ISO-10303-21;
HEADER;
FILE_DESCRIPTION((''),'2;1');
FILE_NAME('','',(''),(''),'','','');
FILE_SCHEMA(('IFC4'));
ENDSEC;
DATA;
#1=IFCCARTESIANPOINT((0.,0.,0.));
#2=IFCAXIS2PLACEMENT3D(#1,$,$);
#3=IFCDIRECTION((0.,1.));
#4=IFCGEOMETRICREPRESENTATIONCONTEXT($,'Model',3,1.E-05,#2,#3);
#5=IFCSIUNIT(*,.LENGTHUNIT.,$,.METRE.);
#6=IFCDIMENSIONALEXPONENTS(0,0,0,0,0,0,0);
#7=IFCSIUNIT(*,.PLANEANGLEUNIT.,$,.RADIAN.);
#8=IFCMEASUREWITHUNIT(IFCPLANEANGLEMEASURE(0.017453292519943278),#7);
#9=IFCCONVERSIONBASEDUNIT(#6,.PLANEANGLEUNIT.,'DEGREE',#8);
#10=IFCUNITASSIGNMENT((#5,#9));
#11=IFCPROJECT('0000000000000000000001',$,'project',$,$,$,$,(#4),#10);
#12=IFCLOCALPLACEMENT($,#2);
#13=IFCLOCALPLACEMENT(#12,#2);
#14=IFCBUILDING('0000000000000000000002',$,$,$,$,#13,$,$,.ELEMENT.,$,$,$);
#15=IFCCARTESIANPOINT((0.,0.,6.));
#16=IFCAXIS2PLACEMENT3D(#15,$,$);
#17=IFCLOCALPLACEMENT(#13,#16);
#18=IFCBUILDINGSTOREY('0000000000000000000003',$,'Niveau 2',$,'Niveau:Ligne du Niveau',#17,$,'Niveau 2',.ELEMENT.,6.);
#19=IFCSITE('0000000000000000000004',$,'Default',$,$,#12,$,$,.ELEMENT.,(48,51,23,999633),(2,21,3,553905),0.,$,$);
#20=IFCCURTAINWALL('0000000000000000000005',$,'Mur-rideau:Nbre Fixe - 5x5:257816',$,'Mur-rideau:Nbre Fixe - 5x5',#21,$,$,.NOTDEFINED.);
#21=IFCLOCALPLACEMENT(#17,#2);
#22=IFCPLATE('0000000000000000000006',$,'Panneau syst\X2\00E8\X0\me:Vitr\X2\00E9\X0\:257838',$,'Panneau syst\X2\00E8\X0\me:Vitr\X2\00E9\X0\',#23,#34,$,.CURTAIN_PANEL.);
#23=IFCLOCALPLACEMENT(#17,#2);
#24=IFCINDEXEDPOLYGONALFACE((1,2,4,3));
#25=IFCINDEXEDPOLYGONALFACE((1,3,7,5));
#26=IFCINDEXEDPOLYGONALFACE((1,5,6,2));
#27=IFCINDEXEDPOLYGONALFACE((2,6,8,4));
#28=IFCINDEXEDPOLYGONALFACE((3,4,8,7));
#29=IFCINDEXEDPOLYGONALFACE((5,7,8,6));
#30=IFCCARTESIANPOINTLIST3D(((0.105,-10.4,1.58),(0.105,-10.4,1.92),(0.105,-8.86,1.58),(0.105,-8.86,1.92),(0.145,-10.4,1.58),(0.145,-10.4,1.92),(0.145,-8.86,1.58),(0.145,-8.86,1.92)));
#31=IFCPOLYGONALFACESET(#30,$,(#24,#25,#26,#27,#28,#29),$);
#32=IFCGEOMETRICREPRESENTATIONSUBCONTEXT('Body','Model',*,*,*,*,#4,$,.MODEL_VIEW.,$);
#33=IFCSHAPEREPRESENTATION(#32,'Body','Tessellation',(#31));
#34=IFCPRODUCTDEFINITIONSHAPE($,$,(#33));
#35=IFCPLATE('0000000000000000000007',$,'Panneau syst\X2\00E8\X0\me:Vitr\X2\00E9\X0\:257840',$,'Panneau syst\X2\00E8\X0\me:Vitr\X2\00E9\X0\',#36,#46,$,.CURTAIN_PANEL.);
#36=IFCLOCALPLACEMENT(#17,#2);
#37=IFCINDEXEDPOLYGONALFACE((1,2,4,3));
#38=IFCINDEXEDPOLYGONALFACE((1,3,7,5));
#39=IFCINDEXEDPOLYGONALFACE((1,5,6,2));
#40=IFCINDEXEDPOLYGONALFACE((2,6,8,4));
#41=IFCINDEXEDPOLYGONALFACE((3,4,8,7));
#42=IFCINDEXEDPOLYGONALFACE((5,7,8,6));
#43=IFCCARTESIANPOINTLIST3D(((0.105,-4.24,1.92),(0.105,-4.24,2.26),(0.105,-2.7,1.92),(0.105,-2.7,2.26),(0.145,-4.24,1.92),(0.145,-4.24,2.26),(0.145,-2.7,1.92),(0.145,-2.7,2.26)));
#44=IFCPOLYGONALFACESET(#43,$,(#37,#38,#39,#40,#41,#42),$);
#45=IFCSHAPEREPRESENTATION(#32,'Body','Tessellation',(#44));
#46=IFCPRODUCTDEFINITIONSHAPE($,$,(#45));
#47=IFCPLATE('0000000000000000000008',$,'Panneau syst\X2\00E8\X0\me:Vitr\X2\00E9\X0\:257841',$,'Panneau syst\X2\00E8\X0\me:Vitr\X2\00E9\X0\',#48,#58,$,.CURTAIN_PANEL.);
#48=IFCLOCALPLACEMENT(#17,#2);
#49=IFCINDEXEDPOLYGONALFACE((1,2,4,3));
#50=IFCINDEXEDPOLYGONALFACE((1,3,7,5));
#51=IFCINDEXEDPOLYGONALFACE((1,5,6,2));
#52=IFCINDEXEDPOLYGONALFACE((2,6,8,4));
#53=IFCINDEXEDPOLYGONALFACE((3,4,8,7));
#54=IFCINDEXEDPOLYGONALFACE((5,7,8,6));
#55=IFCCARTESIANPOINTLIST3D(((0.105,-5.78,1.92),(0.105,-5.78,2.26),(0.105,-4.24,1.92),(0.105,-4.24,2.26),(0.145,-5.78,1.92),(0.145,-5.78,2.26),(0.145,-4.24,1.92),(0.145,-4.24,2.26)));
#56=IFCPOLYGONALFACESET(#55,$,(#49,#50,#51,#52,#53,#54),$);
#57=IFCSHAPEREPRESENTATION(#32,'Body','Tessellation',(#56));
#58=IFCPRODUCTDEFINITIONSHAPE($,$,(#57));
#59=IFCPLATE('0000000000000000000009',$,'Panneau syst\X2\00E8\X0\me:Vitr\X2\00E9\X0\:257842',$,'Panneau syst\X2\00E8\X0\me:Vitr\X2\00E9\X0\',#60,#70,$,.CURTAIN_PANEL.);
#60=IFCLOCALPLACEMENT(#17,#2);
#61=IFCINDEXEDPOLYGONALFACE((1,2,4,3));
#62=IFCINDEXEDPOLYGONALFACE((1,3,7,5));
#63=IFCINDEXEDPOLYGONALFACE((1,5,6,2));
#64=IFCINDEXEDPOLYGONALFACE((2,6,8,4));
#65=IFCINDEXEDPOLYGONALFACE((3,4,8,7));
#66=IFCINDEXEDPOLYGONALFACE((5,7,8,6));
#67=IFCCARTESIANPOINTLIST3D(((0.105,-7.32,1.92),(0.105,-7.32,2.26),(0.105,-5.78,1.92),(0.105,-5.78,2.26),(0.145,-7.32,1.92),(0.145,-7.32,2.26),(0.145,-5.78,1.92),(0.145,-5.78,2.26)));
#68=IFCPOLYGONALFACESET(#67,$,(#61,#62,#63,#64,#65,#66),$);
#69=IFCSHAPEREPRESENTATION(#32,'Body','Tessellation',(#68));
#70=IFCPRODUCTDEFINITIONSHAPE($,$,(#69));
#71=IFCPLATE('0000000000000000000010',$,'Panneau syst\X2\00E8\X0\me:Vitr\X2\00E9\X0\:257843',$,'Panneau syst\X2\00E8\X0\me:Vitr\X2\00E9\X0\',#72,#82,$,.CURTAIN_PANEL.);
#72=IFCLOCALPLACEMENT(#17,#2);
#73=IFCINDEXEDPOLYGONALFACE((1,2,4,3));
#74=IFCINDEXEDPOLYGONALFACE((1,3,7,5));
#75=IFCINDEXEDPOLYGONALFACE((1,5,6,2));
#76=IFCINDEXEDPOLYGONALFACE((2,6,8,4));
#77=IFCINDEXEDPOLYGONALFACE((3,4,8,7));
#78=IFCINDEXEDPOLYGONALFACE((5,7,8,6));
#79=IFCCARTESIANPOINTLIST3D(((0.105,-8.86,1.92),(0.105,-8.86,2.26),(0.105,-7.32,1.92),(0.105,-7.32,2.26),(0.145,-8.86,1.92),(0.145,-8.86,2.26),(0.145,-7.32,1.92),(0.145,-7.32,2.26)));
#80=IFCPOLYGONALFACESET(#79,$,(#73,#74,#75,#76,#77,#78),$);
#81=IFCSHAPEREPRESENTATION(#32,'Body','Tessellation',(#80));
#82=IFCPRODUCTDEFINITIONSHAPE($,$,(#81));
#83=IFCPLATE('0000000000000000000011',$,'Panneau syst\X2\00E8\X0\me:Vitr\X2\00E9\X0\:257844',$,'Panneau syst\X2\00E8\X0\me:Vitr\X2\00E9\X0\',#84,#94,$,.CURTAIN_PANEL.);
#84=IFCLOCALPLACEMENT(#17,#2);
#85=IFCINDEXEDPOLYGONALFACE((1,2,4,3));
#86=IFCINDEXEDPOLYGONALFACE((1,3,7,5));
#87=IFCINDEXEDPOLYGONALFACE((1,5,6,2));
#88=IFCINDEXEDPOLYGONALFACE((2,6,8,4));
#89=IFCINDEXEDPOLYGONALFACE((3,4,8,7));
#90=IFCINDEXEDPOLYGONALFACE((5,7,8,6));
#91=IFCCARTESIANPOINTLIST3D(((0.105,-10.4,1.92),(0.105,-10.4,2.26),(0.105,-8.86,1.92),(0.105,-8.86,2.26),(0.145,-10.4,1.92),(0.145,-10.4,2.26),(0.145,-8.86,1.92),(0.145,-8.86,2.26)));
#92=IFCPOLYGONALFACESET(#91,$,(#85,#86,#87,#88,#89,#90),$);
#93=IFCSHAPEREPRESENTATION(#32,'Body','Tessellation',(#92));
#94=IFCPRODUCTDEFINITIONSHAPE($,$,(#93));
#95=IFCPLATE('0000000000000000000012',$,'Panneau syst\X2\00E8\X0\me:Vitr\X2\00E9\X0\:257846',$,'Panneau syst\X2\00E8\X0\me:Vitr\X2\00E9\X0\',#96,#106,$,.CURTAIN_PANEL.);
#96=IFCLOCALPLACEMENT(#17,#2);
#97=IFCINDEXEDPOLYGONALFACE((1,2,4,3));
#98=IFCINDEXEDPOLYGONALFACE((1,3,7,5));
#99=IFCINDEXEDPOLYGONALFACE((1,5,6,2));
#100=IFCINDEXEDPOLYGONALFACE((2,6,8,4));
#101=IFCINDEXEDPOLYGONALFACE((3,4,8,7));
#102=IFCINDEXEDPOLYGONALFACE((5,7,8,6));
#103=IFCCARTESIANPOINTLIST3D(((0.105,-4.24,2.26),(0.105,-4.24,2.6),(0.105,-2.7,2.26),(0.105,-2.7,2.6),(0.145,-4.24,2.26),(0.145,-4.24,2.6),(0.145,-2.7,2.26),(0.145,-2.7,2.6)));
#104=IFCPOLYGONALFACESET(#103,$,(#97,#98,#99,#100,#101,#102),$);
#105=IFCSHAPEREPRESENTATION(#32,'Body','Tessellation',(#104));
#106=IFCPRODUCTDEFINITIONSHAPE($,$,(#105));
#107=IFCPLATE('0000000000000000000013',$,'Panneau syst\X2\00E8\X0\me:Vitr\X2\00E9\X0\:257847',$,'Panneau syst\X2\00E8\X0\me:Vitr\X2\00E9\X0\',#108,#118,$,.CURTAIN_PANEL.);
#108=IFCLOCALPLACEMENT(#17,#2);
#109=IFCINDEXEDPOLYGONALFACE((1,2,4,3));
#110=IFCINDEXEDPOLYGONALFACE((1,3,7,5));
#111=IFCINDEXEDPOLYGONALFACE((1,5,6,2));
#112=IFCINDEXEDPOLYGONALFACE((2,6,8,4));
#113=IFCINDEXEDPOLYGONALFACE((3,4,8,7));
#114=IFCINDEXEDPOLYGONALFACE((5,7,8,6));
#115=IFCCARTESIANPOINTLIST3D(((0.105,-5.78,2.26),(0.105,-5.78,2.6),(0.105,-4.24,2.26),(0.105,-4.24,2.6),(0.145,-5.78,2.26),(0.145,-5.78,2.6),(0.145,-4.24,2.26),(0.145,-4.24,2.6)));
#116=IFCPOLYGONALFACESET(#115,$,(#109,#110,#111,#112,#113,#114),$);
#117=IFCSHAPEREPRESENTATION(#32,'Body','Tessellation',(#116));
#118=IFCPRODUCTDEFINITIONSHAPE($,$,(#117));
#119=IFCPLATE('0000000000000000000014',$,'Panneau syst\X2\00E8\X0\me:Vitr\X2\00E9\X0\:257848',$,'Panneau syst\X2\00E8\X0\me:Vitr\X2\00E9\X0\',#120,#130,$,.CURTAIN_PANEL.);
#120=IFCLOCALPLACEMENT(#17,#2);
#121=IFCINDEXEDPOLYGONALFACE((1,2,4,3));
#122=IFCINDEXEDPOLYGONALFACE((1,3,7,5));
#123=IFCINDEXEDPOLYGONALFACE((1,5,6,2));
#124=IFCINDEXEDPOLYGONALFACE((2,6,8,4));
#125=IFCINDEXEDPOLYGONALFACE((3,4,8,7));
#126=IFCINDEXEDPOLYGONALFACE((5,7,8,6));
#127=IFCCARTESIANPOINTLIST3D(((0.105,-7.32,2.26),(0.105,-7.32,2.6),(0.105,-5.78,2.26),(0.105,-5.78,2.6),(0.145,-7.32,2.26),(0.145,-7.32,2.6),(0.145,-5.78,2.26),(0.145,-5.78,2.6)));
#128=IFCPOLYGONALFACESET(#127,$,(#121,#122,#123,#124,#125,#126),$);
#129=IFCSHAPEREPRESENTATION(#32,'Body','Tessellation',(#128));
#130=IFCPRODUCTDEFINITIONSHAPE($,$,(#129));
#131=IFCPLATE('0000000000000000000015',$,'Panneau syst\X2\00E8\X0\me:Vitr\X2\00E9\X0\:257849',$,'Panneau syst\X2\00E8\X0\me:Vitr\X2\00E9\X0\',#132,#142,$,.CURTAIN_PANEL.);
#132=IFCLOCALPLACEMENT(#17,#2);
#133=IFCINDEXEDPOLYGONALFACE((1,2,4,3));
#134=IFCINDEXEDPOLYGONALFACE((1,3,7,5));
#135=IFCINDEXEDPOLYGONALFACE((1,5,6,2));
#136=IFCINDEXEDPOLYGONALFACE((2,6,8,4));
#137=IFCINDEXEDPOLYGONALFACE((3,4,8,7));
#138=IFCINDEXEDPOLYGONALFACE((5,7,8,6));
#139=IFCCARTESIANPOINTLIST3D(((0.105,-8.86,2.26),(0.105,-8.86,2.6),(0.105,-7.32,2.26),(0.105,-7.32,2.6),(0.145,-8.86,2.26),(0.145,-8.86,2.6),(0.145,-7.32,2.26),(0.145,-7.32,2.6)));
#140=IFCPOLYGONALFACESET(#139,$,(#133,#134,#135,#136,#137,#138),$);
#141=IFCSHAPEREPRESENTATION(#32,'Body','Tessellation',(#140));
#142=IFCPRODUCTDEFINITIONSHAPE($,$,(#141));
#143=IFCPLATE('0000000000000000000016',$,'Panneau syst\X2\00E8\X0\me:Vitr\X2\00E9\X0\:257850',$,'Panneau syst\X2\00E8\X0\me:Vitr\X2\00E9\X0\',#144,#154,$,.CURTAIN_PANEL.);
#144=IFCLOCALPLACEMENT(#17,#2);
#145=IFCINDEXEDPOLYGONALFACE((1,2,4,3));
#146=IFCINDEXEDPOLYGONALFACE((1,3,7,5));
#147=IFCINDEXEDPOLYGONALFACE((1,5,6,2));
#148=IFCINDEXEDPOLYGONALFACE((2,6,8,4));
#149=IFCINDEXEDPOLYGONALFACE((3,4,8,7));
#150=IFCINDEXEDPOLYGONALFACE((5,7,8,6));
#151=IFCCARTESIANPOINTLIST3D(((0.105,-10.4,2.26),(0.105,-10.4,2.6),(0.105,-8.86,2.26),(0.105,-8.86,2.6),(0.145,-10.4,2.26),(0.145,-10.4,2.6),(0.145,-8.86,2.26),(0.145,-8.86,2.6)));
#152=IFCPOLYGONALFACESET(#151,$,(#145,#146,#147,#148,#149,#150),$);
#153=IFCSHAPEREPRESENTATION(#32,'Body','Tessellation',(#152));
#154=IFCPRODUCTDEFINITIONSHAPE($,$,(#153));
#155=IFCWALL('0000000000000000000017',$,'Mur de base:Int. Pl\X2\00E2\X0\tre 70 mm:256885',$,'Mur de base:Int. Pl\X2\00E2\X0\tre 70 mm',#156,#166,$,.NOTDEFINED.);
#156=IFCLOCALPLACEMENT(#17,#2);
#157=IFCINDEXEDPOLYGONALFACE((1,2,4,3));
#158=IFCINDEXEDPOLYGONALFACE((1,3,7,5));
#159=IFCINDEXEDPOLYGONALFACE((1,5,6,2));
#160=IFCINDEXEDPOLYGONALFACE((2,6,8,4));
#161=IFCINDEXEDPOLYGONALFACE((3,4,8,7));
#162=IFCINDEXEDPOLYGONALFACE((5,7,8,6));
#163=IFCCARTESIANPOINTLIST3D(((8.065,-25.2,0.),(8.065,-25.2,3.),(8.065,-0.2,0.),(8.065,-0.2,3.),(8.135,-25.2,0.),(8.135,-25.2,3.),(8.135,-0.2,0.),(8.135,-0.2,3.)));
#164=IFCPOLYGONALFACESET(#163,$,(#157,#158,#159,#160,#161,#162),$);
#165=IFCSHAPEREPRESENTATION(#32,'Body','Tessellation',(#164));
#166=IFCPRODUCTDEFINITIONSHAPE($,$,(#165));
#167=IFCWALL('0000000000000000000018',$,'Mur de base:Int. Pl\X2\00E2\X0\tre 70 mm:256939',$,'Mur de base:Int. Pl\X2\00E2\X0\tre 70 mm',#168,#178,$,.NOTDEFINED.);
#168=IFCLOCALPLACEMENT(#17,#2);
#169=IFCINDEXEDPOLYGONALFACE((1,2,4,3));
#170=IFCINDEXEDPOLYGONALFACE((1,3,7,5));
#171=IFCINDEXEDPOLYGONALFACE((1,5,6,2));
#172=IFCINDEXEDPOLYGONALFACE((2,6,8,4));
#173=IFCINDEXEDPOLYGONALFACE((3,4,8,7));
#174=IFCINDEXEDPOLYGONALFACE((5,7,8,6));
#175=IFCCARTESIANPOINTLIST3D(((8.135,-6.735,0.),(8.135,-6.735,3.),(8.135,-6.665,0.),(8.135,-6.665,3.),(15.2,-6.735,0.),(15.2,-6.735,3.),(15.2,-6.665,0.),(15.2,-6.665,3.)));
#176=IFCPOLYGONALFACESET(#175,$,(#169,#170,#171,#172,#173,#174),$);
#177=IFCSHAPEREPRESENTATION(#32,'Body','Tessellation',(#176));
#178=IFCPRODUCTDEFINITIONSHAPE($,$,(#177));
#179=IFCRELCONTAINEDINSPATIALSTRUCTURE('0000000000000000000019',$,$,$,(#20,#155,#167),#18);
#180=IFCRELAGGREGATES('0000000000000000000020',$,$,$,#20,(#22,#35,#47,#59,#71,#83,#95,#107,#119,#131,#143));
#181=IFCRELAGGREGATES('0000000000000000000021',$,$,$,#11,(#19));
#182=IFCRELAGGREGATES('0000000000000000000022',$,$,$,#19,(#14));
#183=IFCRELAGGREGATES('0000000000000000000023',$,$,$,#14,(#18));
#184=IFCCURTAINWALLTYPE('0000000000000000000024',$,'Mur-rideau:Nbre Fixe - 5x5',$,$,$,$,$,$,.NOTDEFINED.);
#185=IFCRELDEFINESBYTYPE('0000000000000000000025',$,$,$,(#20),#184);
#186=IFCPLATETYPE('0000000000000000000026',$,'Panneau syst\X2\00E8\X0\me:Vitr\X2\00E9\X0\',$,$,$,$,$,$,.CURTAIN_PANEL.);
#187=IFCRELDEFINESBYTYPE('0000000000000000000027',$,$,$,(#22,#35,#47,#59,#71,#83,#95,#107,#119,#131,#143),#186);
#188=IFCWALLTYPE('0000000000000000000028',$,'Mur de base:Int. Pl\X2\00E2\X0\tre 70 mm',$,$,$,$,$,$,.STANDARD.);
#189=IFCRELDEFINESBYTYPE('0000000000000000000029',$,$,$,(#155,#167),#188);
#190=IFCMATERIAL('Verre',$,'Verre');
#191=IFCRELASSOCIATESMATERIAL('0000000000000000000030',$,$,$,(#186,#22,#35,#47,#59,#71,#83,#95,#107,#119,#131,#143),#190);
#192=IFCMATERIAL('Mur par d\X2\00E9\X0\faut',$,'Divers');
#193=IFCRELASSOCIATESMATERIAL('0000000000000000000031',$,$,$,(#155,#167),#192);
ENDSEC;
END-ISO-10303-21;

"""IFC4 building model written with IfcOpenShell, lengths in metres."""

from ifc_helpers import new_model, entity, si_unit, converted_unit, direction, frame, origin, place, context, subcontext, project, spatial, indexed_curve, outline, extrude, source, transform, mapped, material, type_object, type_shapes, element, aggregate, save


model = new_model("IFC4")

# Units and contexts
model_context = context("Model", 3, precision=1e-05, world=origin(), true_north=direction((0.0, 1.0)))
body_context = subcontext(model_context, "Body", "Model", "MODEL_VIEW")
ifc_project = project(units=[si_unit("LENGTHUNIT", "METRE"), converted_unit("PLANEANGLEUNIT", "DEGREE", entity("IfcPlaneAngleMeasure", 0.017453292519943278), si_unit("PLANEANGLEUNIT", "RADIAN"), dimensions=[0, 0, 0, 0, 0, 0, 0])], contexts=[model_context])

# Site, building, storey
site_placement = place(None, origin())
site = spatial("IfcSite", under=ifc_project, at=site_placement, Name="Default", CompositionType="ELEMENT", RefLatitude=(48, 51, 23, 999633), RefLongitude=(2, 21, 3, 553905), RefElevation=0.0)
building_placement = place(site_placement, origin())
building = spatial("IfcBuilding", under=site, at=building_placement, CompositionType="ELEMENT")
storey_placement = place(building_placement, frame((0.0, 0.0, 6.0)))
storey = spatial("IfcBuildingStorey", under=building, at=storey_placement, Name="Niveau 2", ObjectType="Niveau:Ligne du Niveau", LongName="Niveau 2", CompositionType="ELEMENT", Elevation=6.0)

# Curtain wall, plates
curtain_wall_type = type_object("IfcCurtainWallType", Name="Mur-rideau:Nbre Fixe - 5x5", PredefinedType="NOTDEFINED")
curtain_wall_placement = place(storey_placement, frame((0.0, 0.0, -6.0)))
curtain_wall = element("IfcCurtainWall", 1, at=curtain_wall_placement, inside=storey, type_object=curtain_wall_type, Name="Mur-rideau:Nbre Fixe - 5x5:257816", ObjectType="Mur-rideau:Nbre Fixe - 5x5", PredefinedType="NOTDEFINED")
ifc_material_1 = material(Name="Verre", Category="Verre")
plate_type = type_object("IfcPlateType", Name="Panneau système:Vitré", PredefinedType="CURTAIN_PANEL", material=ifc_material_1)
shared_shape = source(origin(), body_context, "Body", "SweptSolid", [
    extrude(outline(indexed_curve([(-0.02, -0.77), (0.02, -0.77), (0.02, 0.77), (-0.02, 0.77), (-0.02, -0.77)], self_intersect=False)), frame((0.77, 0.02, 0.0), z_axis=(0.0, 0.0, 1.0), x_axis=(0.0, 1.0, 0.0)), (0.0, 0.0, 1.0), 0.34),
])
type_shapes(plate_type, [shared_shape])
plate_1_placement = place(curtain_wall_placement, frame((0.105, -8.86, 7.58), z_axis=(0.0, 0.0, 1.0), x_axis=(0.0, -1.0, 0.0)))
plate_1 = element("IfcPlate", 2, at=plate_1_placement, type_object=plate_type, material=ifc_material_1, Name="Panneau système:Vitré:257838", ObjectType="Panneau système:Vitré", PredefinedType="CURTAIN_PANEL", context=body_context, shape_type="MappedRepresentation", body=[
    mapped(shared_shape, transform((0.0, 0.0, 0.0), scale=1.0)),
])
plate_2_placement = place(curtain_wall_placement, frame((0.105, -2.7, 7.92), z_axis=(0.0, 0.0, 1.0), x_axis=(0.0, -1.0, 0.0)))
plate_2 = element("IfcPlate", 3, at=plate_2_placement, type_object=plate_type, material=ifc_material_1, Name="Panneau système:Vitré:257840", ObjectType="Panneau système:Vitré", PredefinedType="CURTAIN_PANEL", context=body_context, shape_type="MappedRepresentation", body=[
    mapped(shared_shape, transform((0.0, 0.0, 0.0), scale=1.0)),
])
plate_3_placement = place(curtain_wall_placement, frame((0.105, -4.24, 7.92), z_axis=(0.0, 0.0, 1.0), x_axis=(0.0, -1.0, 0.0)))
plate_3 = element("IfcPlate", 4, at=plate_3_placement, type_object=plate_type, material=ifc_material_1, Name="Panneau système:Vitré:257841", ObjectType="Panneau système:Vitré", PredefinedType="CURTAIN_PANEL", context=body_context, shape_type="MappedRepresentation", body=[
    mapped(shared_shape, transform((0.0, 0.0, 0.0), scale=1.0)),
])
plate_4_placement = place(curtain_wall_placement, frame((0.105, -5.78, 7.92), z_axis=(0.0, 0.0, 1.0), x_axis=(0.0, -1.0, 0.0)))
plate_4 = element("IfcPlate", 5, at=plate_4_placement, type_object=plate_type, material=ifc_material_1, Name="Panneau système:Vitré:257842", ObjectType="Panneau système:Vitré", PredefinedType="CURTAIN_PANEL", context=body_context, shape_type="MappedRepresentation", body=[
    mapped(shared_shape, transform((0.0, 0.0, 0.0), scale=1.0)),
])
plate_5_placement = place(curtain_wall_placement, frame((0.105, -7.32, 7.92), z_axis=(0.0, 0.0, 1.0), x_axis=(0.0, -1.0, 0.0)))
plate_5 = element("IfcPlate", 6, at=plate_5_placement, type_object=plate_type, material=ifc_material_1, Name="Panneau système:Vitré:257843", ObjectType="Panneau système:Vitré", PredefinedType="CURTAIN_PANEL", context=body_context, shape_type="MappedRepresentation", body=[
    mapped(shared_shape, transform((0.0, 0.0, 0.0), scale=1.0)),
])
plate_6_placement = place(curtain_wall_placement, frame((0.105, -8.86, 7.92), z_axis=(0.0, 0.0, 1.0), x_axis=(0.0, -1.0, 0.0)))
plate_6 = element("IfcPlate", 7, at=plate_6_placement, type_object=plate_type, material=ifc_material_1, Name="Panneau système:Vitré:257844", ObjectType="Panneau système:Vitré", PredefinedType="CURTAIN_PANEL", context=body_context, shape_type="MappedRepresentation", body=[
    mapped(shared_shape, transform((0.0, 0.0, 0.0), scale=1.0)),
])
plate_7_placement = place(curtain_wall_placement, frame((0.105, -2.7, 8.26), z_axis=(0.0, 0.0, 1.0), x_axis=(0.0, -1.0, 0.0)))
plate_7 = element("IfcPlate", 8, at=plate_7_placement, type_object=plate_type, material=ifc_material_1, Name="Panneau système:Vitré:257846", ObjectType="Panneau système:Vitré", PredefinedType="CURTAIN_PANEL", context=body_context, shape_type="MappedRepresentation", body=[
    mapped(shared_shape, transform((0.0, 0.0, 0.0), scale=1.0)),
])
plate_8_placement = place(curtain_wall_placement, frame((0.105, -4.24, 8.26), z_axis=(0.0, 0.0, 1.0), x_axis=(0.0, -1.0, 0.0)))
plate_8 = element("IfcPlate", 9, at=plate_8_placement, type_object=plate_type, material=ifc_material_1, Name="Panneau système:Vitré:257847", ObjectType="Panneau système:Vitré", PredefinedType="CURTAIN_PANEL", context=body_context, shape_type="MappedRepresentation", body=[
    mapped(shared_shape, transform((0.0, 0.0, 0.0), scale=1.0)),
])
plate_9_placement = place(curtain_wall_placement, frame((0.105, -5.78, 8.26), z_axis=(0.0, 0.0, 1.0), x_axis=(0.0, -1.0, 0.0)))
plate_9 = element("IfcPlate", 10, at=plate_9_placement, type_object=plate_type, material=ifc_material_1, Name="Panneau système:Vitré:257848", ObjectType="Panneau système:Vitré", PredefinedType="CURTAIN_PANEL", context=body_context, shape_type="MappedRepresentation", body=[
    mapped(shared_shape, transform((0.0, 0.0, 0.0), scale=1.0)),
])
plate_10_placement = place(curtain_wall_placement, frame((0.105, -7.32, 8.26), z_axis=(0.0, 0.0, 1.0), x_axis=(0.0, -1.0, 0.0)))
plate_10 = element("IfcPlate", 11, at=plate_10_placement, type_object=plate_type, material=ifc_material_1, Name="Panneau système:Vitré:257849", ObjectType="Panneau système:Vitré", PredefinedType="CURTAIN_PANEL", context=body_context, shape_type="MappedRepresentation", body=[
    mapped(shared_shape, transform((0.0, 0.0, 0.0), scale=1.0)),
])
plate_11_placement = place(curtain_wall_placement, frame((0.105, -8.86, 8.26), z_axis=(0.0, 0.0, 1.0), x_axis=(0.0, -1.0, 0.0)))
plate_11 = element("IfcPlate", 12, at=plate_11_placement, type_object=plate_type, material=ifc_material_1, Name="Panneau système:Vitré:257850", ObjectType="Panneau système:Vitré", PredefinedType="CURTAIN_PANEL", context=body_context, shape_type="MappedRepresentation", body=[
    mapped(shared_shape, transform((0.0, 0.0, 0.0), scale=1.0)),
])
aggregate(curtain_wall, [plate_1, plate_2, plate_3, plate_4, plate_5, plate_6, plate_7, plate_8, plate_9, plate_10, plate_11])

# Walls
ifc_material_2 = material(Name="Mur par défaut", Category="Divers")
wall_type = type_object("IfcWallType", Name="Mur de base:Int. Plâtre 70 mm", PredefinedType="STANDARD")
wall_1_placement = place(storey_placement, frame((8.1, -0.2, 0.0), z_axis=(0.0, 0.0, 1.0), x_axis=(0.0, -1.0, 0.0)))
element("IfcWall", 13, at=wall_1_placement, inside=storey, type_object=wall_type, material=ifc_material_2, Name="Mur de base:Int. Plâtre 70 mm:256885", ObjectType="Mur de base:Int. Plâtre 70 mm", PredefinedType="NOTDEFINED", context=body_context, shape_type="SweptSolid", body=[
    extrude(outline(indexed_curve([(25.0, 0.035), (0.0, 0.035), (0.0, -0.035), (25.0, -0.035), (25.0, 0.035)], self_intersect=False)), origin(), (0.0, 0.0, 1.0), 3.0),
])
wall_2_placement = place(storey_placement, frame((8.135, -6.7, 0.0)))
element("IfcWall", 14, at=wall_2_placement, inside=storey, type_object=wall_type, material=ifc_material_2, Name="Mur de base:Int. Plâtre 70 mm:256939", ObjectType="Mur de base:Int. Plâtre 70 mm", PredefinedType="NOTDEFINED", context=body_context, shape_type="SweptSolid", body=[
    extrude(outline(indexed_curve([(7.065, 0.035), (0.0, 0.035), (0.0, -0.035), (7.065, -0.035), (7.065, 0.035)], self_intersect=False)), origin(), (0.0, 0.0, 1.0), 3.0),
])

save(model, "model.ifc")
